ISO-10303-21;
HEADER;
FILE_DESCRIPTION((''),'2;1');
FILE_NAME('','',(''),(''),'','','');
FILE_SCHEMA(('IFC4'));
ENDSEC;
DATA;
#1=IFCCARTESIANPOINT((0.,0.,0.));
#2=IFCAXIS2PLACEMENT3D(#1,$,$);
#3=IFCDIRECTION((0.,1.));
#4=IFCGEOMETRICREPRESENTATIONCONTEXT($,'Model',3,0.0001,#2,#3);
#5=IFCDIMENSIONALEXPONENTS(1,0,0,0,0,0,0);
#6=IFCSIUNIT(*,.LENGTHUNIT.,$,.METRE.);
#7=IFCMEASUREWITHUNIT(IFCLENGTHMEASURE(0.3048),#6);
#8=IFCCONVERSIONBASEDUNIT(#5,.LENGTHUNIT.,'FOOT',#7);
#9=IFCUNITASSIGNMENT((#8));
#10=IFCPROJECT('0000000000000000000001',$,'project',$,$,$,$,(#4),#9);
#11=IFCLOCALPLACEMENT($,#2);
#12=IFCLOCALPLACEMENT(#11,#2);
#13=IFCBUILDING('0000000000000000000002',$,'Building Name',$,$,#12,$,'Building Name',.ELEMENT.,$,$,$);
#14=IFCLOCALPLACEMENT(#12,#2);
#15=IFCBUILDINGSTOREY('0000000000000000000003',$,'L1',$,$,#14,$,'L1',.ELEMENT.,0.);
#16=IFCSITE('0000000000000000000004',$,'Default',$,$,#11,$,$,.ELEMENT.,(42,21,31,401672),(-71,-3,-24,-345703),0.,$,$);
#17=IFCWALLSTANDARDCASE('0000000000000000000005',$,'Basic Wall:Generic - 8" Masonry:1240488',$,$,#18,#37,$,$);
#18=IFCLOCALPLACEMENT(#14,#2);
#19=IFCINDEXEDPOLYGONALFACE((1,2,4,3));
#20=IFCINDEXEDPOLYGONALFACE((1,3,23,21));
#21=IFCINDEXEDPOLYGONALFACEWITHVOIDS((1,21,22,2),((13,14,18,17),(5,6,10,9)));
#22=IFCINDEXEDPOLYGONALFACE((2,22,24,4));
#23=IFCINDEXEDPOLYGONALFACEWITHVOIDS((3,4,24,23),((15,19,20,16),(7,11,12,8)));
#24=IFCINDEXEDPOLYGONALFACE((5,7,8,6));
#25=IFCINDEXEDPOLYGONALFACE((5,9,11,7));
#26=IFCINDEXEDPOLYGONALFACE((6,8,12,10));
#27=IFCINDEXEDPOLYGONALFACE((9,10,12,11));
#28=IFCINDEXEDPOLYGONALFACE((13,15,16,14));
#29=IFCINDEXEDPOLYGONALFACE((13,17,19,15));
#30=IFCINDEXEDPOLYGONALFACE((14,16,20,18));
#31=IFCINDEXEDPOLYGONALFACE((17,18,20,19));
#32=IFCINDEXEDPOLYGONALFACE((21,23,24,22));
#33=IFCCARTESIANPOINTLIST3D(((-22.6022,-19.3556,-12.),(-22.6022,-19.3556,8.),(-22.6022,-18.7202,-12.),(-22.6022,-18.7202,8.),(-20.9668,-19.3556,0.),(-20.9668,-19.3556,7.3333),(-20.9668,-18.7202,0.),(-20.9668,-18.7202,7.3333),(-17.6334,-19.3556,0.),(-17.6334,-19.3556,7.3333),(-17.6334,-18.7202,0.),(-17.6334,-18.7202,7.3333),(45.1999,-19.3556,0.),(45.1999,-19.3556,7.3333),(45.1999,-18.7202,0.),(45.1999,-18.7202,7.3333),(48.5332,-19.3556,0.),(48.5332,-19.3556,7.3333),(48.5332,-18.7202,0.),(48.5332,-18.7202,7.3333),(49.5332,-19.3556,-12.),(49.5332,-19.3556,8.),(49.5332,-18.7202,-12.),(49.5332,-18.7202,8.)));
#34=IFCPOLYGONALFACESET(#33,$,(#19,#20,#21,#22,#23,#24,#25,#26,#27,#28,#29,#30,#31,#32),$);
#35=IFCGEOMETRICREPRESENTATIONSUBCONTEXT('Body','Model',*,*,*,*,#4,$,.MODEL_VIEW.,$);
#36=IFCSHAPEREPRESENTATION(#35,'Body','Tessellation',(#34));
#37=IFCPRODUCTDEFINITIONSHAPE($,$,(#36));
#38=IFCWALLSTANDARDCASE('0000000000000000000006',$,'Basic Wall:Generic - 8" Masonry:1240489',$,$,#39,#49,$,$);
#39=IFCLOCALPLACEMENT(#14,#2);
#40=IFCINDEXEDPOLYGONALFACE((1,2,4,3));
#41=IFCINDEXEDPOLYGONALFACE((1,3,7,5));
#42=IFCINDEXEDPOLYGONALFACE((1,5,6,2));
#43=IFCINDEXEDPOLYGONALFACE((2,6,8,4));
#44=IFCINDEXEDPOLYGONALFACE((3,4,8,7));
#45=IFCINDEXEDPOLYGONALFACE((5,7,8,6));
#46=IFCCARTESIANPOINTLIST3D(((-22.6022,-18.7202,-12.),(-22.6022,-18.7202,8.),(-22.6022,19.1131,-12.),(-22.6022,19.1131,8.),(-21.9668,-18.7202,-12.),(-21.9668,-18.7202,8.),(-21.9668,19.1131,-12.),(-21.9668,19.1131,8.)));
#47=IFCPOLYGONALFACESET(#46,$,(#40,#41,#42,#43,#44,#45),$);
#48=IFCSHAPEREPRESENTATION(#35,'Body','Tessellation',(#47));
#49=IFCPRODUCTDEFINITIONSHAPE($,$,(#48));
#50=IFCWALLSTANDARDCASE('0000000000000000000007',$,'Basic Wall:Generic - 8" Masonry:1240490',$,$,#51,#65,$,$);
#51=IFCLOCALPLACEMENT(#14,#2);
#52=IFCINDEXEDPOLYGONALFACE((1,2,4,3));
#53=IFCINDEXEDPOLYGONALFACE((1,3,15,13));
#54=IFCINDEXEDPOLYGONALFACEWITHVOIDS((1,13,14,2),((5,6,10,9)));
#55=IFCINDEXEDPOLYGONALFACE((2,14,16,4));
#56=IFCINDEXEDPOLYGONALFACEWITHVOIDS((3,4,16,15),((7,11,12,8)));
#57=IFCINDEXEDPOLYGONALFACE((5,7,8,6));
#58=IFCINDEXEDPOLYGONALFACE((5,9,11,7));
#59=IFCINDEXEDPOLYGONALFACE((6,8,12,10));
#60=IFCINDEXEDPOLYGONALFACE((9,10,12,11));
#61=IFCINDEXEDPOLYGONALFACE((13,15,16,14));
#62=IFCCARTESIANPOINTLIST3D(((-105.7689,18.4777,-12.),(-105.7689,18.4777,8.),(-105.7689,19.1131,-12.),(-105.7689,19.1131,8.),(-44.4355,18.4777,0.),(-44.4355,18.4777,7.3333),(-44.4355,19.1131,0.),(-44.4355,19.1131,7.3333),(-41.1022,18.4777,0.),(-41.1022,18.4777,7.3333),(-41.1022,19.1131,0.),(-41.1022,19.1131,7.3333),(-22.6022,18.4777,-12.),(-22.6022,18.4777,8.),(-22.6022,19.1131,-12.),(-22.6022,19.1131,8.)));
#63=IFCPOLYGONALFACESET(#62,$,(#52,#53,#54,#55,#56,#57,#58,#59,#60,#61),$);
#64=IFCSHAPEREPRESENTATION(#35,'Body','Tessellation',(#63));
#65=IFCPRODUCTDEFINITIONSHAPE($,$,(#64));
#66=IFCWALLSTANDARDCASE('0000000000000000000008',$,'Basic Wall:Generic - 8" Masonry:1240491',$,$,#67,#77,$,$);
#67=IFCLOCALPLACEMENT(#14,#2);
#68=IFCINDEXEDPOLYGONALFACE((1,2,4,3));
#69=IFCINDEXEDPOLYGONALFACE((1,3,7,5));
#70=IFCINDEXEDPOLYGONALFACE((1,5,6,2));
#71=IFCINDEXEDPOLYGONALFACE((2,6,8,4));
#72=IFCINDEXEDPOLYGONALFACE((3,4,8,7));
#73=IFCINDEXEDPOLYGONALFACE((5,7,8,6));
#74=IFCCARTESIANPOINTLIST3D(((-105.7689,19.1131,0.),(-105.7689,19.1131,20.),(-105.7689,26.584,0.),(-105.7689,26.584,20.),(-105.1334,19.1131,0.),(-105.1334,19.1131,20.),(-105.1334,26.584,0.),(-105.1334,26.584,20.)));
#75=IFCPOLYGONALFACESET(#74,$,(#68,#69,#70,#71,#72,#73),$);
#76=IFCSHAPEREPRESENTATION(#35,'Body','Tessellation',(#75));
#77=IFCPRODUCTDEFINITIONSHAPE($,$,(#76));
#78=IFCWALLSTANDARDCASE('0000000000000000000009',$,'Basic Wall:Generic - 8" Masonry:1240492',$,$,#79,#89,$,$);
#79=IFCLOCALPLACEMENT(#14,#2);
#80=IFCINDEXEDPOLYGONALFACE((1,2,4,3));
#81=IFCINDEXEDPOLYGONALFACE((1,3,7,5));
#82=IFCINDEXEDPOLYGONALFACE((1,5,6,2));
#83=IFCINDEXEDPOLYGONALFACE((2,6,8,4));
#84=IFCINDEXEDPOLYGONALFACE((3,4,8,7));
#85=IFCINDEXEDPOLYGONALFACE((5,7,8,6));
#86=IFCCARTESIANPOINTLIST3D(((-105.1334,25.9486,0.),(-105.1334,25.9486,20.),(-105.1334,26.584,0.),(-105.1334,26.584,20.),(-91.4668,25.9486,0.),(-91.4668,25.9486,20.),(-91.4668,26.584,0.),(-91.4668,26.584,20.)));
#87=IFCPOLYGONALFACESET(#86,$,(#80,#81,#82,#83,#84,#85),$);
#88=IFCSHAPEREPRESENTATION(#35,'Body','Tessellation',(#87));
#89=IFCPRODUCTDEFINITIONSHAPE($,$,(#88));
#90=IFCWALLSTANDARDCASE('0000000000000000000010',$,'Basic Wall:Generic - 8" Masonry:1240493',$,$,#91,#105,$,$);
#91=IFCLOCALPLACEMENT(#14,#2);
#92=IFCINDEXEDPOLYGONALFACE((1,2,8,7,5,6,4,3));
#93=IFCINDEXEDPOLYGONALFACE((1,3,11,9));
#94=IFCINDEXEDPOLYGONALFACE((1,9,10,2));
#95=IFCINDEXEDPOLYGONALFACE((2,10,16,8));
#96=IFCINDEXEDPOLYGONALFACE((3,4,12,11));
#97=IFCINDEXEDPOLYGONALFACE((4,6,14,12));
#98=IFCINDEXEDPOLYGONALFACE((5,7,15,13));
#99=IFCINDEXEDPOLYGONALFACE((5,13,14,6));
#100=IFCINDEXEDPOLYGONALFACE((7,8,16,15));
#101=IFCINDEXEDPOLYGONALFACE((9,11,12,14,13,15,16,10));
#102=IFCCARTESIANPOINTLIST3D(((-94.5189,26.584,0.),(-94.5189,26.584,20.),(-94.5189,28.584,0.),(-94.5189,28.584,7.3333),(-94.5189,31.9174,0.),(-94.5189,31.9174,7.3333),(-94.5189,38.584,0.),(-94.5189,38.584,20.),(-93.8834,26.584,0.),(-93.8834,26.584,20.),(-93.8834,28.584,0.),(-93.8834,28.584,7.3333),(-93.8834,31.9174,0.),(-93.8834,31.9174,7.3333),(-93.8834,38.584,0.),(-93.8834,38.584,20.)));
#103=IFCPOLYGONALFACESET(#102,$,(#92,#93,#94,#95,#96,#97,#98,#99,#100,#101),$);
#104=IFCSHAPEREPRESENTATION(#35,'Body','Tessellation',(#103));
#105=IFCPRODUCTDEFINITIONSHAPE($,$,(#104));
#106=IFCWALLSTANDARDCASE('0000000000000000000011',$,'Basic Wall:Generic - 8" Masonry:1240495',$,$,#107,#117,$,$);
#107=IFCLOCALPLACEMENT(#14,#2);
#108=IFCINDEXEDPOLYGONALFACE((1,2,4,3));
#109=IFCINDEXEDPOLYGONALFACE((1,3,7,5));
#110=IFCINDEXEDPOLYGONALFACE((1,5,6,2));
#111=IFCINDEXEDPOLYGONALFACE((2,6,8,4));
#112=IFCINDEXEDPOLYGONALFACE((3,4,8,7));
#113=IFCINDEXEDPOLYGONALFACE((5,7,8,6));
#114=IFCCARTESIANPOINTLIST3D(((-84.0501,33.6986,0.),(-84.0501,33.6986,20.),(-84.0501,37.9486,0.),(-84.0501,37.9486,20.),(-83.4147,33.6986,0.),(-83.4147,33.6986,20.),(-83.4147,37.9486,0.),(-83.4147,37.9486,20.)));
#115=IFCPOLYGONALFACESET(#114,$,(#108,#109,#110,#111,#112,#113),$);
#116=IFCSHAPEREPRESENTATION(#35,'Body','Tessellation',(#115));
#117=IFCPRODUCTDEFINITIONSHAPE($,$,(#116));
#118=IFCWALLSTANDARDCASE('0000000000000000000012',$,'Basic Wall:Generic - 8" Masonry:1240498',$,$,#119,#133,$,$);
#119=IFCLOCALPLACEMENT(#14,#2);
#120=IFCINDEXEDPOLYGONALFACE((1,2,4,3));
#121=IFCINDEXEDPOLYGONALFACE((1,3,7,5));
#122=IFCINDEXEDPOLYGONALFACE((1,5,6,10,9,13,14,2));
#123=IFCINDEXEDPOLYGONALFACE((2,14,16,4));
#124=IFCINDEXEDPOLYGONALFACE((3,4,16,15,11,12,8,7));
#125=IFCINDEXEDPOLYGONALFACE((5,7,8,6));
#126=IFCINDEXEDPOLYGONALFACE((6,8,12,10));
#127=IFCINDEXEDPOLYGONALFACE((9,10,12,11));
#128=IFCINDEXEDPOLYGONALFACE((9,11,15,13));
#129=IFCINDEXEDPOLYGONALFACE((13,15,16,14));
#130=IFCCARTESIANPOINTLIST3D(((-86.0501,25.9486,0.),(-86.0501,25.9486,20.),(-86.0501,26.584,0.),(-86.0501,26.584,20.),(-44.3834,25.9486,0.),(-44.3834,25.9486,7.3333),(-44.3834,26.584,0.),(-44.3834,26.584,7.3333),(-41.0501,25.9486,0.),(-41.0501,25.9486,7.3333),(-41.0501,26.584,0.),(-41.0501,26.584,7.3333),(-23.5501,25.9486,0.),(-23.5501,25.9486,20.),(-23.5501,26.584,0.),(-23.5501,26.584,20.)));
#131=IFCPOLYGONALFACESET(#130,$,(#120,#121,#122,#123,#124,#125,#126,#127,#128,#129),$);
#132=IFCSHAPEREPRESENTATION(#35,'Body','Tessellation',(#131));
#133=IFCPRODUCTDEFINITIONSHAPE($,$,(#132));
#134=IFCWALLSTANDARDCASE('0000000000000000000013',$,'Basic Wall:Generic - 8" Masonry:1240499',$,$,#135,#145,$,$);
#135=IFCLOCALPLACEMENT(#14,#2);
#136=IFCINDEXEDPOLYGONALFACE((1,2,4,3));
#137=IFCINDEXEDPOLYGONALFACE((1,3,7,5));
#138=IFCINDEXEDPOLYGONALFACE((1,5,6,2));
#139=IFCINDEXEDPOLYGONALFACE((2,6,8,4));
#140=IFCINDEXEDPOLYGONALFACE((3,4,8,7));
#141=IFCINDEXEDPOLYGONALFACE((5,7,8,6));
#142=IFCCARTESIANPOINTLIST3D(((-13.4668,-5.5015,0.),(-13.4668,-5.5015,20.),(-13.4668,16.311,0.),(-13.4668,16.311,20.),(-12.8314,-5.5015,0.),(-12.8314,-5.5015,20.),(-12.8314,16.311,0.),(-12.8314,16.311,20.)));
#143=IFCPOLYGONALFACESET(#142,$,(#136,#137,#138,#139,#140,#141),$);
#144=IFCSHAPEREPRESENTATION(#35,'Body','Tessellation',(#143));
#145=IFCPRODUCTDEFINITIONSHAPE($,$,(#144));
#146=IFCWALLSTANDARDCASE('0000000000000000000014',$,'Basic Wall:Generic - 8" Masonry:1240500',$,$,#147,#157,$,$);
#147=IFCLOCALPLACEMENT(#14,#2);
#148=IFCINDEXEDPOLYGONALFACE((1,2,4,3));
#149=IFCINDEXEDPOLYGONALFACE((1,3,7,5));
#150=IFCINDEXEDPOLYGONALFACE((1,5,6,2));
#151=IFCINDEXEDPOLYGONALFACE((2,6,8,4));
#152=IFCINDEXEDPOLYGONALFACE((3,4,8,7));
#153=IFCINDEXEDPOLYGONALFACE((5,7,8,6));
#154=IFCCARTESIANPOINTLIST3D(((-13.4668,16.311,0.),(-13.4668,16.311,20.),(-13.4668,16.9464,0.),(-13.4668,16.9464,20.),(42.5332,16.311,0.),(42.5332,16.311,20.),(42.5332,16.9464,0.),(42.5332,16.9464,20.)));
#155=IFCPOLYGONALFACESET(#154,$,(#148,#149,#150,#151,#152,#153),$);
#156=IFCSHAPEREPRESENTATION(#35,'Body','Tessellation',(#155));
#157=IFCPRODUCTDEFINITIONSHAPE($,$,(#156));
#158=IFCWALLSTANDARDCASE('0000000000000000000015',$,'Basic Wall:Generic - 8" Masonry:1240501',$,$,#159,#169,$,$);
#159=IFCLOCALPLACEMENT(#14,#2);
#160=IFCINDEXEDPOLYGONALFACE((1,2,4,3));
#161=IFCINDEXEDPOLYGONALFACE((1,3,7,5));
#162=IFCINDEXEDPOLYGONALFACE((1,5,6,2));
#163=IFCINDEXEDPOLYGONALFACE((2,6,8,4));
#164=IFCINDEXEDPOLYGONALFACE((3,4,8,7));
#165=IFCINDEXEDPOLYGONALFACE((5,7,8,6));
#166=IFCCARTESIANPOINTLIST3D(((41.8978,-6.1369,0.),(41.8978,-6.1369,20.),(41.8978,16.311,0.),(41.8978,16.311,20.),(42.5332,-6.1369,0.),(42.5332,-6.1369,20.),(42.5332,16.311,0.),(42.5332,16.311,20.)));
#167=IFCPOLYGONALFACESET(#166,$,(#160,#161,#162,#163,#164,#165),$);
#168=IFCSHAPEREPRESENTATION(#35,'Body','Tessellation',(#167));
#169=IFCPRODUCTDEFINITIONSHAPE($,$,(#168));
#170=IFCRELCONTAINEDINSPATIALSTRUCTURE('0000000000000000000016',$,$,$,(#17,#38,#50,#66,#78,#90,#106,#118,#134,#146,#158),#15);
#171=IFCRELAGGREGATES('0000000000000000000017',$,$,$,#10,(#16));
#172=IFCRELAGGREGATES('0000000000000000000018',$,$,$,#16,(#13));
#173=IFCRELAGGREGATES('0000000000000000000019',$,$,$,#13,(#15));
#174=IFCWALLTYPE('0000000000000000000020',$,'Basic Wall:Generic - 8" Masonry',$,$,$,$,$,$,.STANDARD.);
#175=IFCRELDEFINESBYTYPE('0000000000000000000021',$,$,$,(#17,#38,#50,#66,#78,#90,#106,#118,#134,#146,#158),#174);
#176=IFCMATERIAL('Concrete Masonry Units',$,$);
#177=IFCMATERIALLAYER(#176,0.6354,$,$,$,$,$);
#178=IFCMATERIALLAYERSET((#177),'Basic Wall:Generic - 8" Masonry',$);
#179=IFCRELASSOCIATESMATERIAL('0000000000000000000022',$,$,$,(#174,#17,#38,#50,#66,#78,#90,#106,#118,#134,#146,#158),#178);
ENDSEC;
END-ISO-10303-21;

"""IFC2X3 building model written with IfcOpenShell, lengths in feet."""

from ifc_helpers import new_model, entity, si_unit, converted_unit, direction, frame, frame_2d, origin, place, context, subcontext, project, spatial, rectangle, extrude, material, layer, layer_set, layer_usage, type_object, element, save


model = new_model("IFC2X3")

# Units and contexts
model_context = context("Model", 3, precision=0.0001, world=origin(), true_north=direction((0.0, 1.0)))
body_context = subcontext(model_context, "Body", "Model", "MODEL_VIEW")
ifc_project = project(units=[converted_unit("LENGTHUNIT", "FOOT", entity("IfcLengthMeasure", 0.3048), si_unit("LENGTHUNIT", "METRE"), dimensions=[1, 0, 0, 0, 0, 0, 0])], contexts=[model_context])

# Site, building, storey
site_placement = place(None, origin())
site = spatial("IfcSite", under=ifc_project, at=site_placement, Name="Default", CompositionType="ELEMENT", RefLatitude=(42, 21, 31, 401672), RefLongitude=(-71, -3, -24, -345703), RefElevation=0.0)
building_placement = place(site_placement, origin())
building = spatial("IfcBuilding", under=site, at=building_placement, Name="Building Name", LongName="Building Name", CompositionType="ELEMENT")
storey_placement = place(building_placement, origin())
storey = spatial("IfcBuildingStorey", under=building, at=storey_placement, Name="L1", LongName="L1", CompositionType="ELEMENT", Elevation=0.0)

# Shared definitions
ifc_material = material(Name="Concrete Masonry Units")
ifc_layer = layer(ifc_material, 0.6354)
ifc_layer_set = layer_set([ifc_layer], Name="Basic Wall:Generic - 8\" Masonry")
wall_type = type_object("IfcWallType", Name="Basic Wall:Generic - 8\" Masonry", PredefinedType="STANDARD", material=ifc_layer_set)

# Wall, openings
ifc_layer_usage_1 = layer_usage(ifc_layer_set, "AXIS2", "NEGATIVE", 0.3177)
wall_1_placement = place(storey_placement, frame((49.5332, -19.0379, -12.0), z_axis=(0.0, 0.0, 1.0), x_axis=(-1.0, 0.0, 0.0)))
wall_1 = element("IfcWallStandardCase", 1, at=wall_1_placement, inside=storey, type_object=wall_type, material=ifc_layer_usage_1, Name="Basic Wall:Generic - 8\" Masonry:1240488", context=body_context, shape_type="SweptSolid", body=[
    extrude(rectangle(XDim=72.1354, YDim=0.6354, at=frame_2d((36.0677, 0.0), x_axis=(-1.0, 0.0))), origin(), (0.0, 0.0, 1.0), 20.0),
])
opening_1_placement = place(wall_1_placement, frame((67.1667, -0.3177, 12.0)))
element("IfcOpeningElement", 2, at=opening_1_placement, cuts=wall_1, ObjectType="Opening", context=body_context, shape_type="SweptSolid", body=[
    extrude(rectangle(XDim=7.3333, YDim=3.3333, at=frame_2d((3.6667, 1.6667), x_axis=(1.0, 0.0))), frame((0.0, 0.0, 0.0), z_axis=(0.0, 1.0, 0.0), x_axis=(0.0, 0.0, 1.0)), (0.0, 0.0, 1.0), 0.6354),
])
opening_2_placement = place(wall_1_placement, frame((1.0, -0.3177, 12.0)))
element("IfcOpeningElement", 3, at=opening_2_placement, cuts=wall_1, ObjectType="Opening", context=body_context, shape_type="SweptSolid", body=[
    extrude(rectangle(XDim=7.3333, YDim=3.3333, at=frame_2d((3.6667, 1.6667), x_axis=(1.0, 0.0))), frame((0.0, 0.0, 0.0), z_axis=(0.0, 1.0, 0.0), x_axis=(0.0, 0.0, 1.0)), (0.0, 0.0, 1.0), 0.6354),
])

# Wall
ifc_layer_usage_2 = layer_usage(ifc_layer_set, "AXIS2", "NEGATIVE", 0.3177)
wall_2_placement = place(storey_placement, frame((-22.2845, 19.1131, -12.0), z_axis=(0.0, 0.0, 1.0), x_axis=(0.0, -1.0, 0.0)))
element("IfcWallStandardCase", 4, at=wall_2_placement, inside=storey, type_object=wall_type, material=ifc_layer_usage_2, Name="Basic Wall:Generic - 8\" Masonry:1240489", context=body_context, shape_type="SweptSolid", body=[
    extrude(rectangle(XDim=37.8333, YDim=0.6354, at=frame_2d((18.9167, 0.0), x_axis=(-1.0, 0.0))), origin(), (0.0, 0.0, 1.0), 20.0),
])

# Wall, opening
ifc_layer_usage_3 = layer_usage(ifc_layer_set, "AXIS2", "NEGATIVE", 0.3177)
wall_3_placement = place(storey_placement, frame((-22.6022, 18.7954, -12.0), z_axis=(0.0, 0.0, 1.0), x_axis=(-1.0, 0.0, 0.0)))
wall_3 = element("IfcWallStandardCase", 5, at=wall_3_placement, inside=storey, type_object=wall_type, material=ifc_layer_usage_3, Name="Basic Wall:Generic - 8\" Masonry:1240490", context=body_context, shape_type="SweptSolid", body=[
    extrude(rectangle(XDim=83.1667, YDim=0.6354, at=frame_2d((41.5833, 0.0), x_axis=(-1.0, 0.0))), origin(), (0.0, 0.0, 1.0), 20.0),
])
opening_3_placement = place(wall_3_placement, frame((18.5, -0.3177, 12.0)))
element("IfcOpeningElement", 6, at=opening_3_placement, cuts=wall_3, ObjectType="Opening", context=body_context, shape_type="SweptSolid", body=[
    extrude(rectangle(XDim=7.3333, YDim=3.3333, at=frame_2d((3.6667, 1.6667), x_axis=(1.0, 0.0))), frame((0.0, 0.0, 0.0), z_axis=(0.0, 1.0, 0.0), x_axis=(0.0, 0.0, 1.0)), (0.0, 0.0, 1.0), 0.6354),
])

# Walls
ifc_layer_usage_4 = layer_usage(ifc_layer_set, "AXIS2", "NEGATIVE", 0.3177)
wall_4_placement = place(storey_placement, frame((-105.4511, 19.1131, 0.0), z_axis=(0.0, 0.0, 1.0), x_axis=(0.0, 1.0, 0.0)))
element("IfcWallStandardCase", 7, at=wall_4_placement, inside=storey, type_object=wall_type, material=ifc_layer_usage_4, Name="Basic Wall:Generic - 8\" Masonry:1240491", context=body_context, shape_type="SweptSolid", body=[
    extrude(rectangle(XDim=7.4709, YDim=0.6354, at=frame_2d((3.7355, 0.0), x_axis=(-1.0, 0.0))), origin(), (0.0, 0.0, 1.0), 20.0),
])
ifc_layer_usage_5 = layer_usage(ifc_layer_set, "AXIS2", "NEGATIVE", 0.3177)
wall_5_placement = place(storey_placement, frame((-105.1334, 26.2663, 0.0)))
element("IfcWallStandardCase", 8, at=wall_5_placement, inside=storey, type_object=wall_type, material=ifc_layer_usage_5, Name="Basic Wall:Generic - 8\" Masonry:1240492", context=body_context, shape_type="SweptSolid", body=[
    extrude(rectangle(XDim=13.6667, YDim=0.6354, at=frame_2d((6.8333, 0.0), x_axis=(-1.0, 0.0))), origin(), (0.0, 0.0, 1.0), 20.0),
])

# Wall, opening
ifc_layer_usage_6 = layer_usage(ifc_layer_set, "AXIS2", "NEGATIVE", 0.3177)
wall_6_placement = place(storey_placement, frame((-94.2011, 26.584, 0.0), z_axis=(0.0, 0.0, 1.0), x_axis=(0.0, 1.0, 0.0)))
wall_6 = element("IfcWallStandardCase", 9, at=wall_6_placement, inside=storey, type_object=wall_type, material=ifc_layer_usage_6, Name="Basic Wall:Generic - 8\" Masonry:1240493", context=body_context, shape_type="SweptSolid", body=[
    extrude(rectangle(XDim=12.0, YDim=0.6354, at=frame_2d((6.0, 0.0), x_axis=(1.0, 0.0))), origin(), (0.0, 0.0, 1.0), 20.0),
])
opening_4_placement = place(wall_6_placement, frame((2.0, -0.3177, 0.0)))
element("IfcOpeningElement", 10, at=opening_4_placement, cuts=wall_6, ObjectType="Opening", context=body_context, shape_type="SweptSolid", body=[
    extrude(rectangle(XDim=7.3333, YDim=3.3333, at=frame_2d((3.6667, 1.6667), x_axis=(1.0, 0.0))), frame((0.0, 0.0, 0.0), z_axis=(0.0, 1.0, 0.0), x_axis=(0.0, 0.0, 1.0)), (0.0, 0.0, 1.0), 0.6354),
])

# Wall
ifc_layer_usage_7 = layer_usage(ifc_layer_set, "AXIS2", "NEGATIVE", 0.3177)
wall_7_placement = place(storey_placement, frame((-83.7324, 37.9486, 0.0), z_axis=(0.0, 0.0, 1.0), x_axis=(0.0, -1.0, 0.0)))
element("IfcWallStandardCase", 11, at=wall_7_placement, inside=storey, type_object=wall_type, material=ifc_layer_usage_7, Name="Basic Wall:Generic - 8\" Masonry:1240495", context=body_context, shape_type="SweptSolid", body=[
    extrude(rectangle(XDim=4.25, YDim=0.6354, at=frame_2d((2.125, 0.0), x_axis=(-1.0, 0.0))), origin(), (0.0, 0.0, 1.0), 20.0),
])

# Wall, opening
ifc_layer_usage_8 = layer_usage(ifc_layer_set, "AXIS2", "NEGATIVE", 0.3177)
wall_8_placement = place(storey_placement, frame((-23.5501, 26.2663, 0.0), z_axis=(0.0, 0.0, 1.0), x_axis=(-1.0, 0.0, 0.0)))
wall_8 = element("IfcWallStandardCase", 12, at=wall_8_placement, inside=storey, type_object=wall_type, material=ifc_layer_usage_8, Name="Basic Wall:Generic - 8\" Masonry:1240498", context=body_context, shape_type="SweptSolid", body=[
    extrude(rectangle(XDim=62.5, YDim=0.6354, at=frame_2d((31.25, 0.0), x_axis=(1.0, 0.0))), origin(), (0.0, 0.0, 1.0), 20.0),
])
opening_5_placement = place(wall_8_placement, frame((20.8333, 0.3177, 0.0)))
element("IfcOpeningElement", 13, at=opening_5_placement, cuts=wall_8, ObjectType="Opening", context=body_context, shape_type="SweptSolid", body=[
    extrude(rectangle(XDim=7.3333, YDim=3.3333, at=frame_2d((3.6667, 1.6667), x_axis=(1.0, 0.0))), frame((0.0, 0.0, 0.0), z_axis=(0.0, -1.0, 0.0), x_axis=(0.0, 0.0, 1.0)), (0.0, 0.0, 1.0), 0.6354),
])

# Walls
ifc_layer_usage_9 = layer_usage(ifc_layer_set, "AXIS2", "NEGATIVE", 0.3177)
wall_9_placement = place(storey_placement, frame((-13.1491, -5.5015, 0.0), z_axis=(0.0, 0.0, 1.0), x_axis=(0.0, 1.0, 0.0)))
element("IfcWallStandardCase", 14, at=wall_9_placement, inside=storey, type_object=wall_type, material=ifc_layer_usage_9, Name="Basic Wall:Generic - 8\" Masonry:1240499", context=body_context, shape_type="SweptSolid", body=[
    extrude(rectangle(XDim=21.8125, YDim=0.6354, at=frame_2d((10.9063, 0.0), x_axis=(-1.0, 0.0))), origin(), (0.0, 0.0, 1.0), 20.0),
])
ifc_layer_usage_10 = layer_usage(ifc_layer_set, "AXIS2", "NEGATIVE", 0.3177)
wall_10_placement = place(storey_placement, frame((-13.4668, 16.6287, 0.0)))
element("IfcWallStandardCase", 15, at=wall_10_placement, inside=storey, type_object=wall_type, material=ifc_layer_usage_10, Name="Basic Wall:Generic - 8\" Masonry:1240500", context=body_context, shape_type="SweptSolid", body=[
    extrude(rectangle(XDim=56.0, YDim=0.6354, at=frame_2d((28.0, 0.0), x_axis=(-1.0, 0.0))), origin(), (0.0, 0.0, 1.0), 20.0),
])
ifc_layer_usage_11 = layer_usage(ifc_layer_set, "AXIS2", "NEGATIVE", 0.3177)
wall_11_placement = place(storey_placement, frame((42.2155, 16.311, 0.0), z_axis=(0.0, 0.0, 1.0), x_axis=(0.0, -1.0, 0.0)))
element("IfcWallStandardCase", 16, at=wall_11_placement, inside=storey, type_object=wall_type, material=ifc_layer_usage_11, Name="Basic Wall:Generic - 8\" Masonry:1240501", context=body_context, shape_type="SweptSolid", body=[
    extrude(rectangle(XDim=22.4479, YDim=0.6354, at=frame_2d((11.224, 0.0), x_axis=(-1.0, 0.0))), origin(), (0.0, 0.0, 1.0), 20.0),
])

save(model, "model.ifc")
